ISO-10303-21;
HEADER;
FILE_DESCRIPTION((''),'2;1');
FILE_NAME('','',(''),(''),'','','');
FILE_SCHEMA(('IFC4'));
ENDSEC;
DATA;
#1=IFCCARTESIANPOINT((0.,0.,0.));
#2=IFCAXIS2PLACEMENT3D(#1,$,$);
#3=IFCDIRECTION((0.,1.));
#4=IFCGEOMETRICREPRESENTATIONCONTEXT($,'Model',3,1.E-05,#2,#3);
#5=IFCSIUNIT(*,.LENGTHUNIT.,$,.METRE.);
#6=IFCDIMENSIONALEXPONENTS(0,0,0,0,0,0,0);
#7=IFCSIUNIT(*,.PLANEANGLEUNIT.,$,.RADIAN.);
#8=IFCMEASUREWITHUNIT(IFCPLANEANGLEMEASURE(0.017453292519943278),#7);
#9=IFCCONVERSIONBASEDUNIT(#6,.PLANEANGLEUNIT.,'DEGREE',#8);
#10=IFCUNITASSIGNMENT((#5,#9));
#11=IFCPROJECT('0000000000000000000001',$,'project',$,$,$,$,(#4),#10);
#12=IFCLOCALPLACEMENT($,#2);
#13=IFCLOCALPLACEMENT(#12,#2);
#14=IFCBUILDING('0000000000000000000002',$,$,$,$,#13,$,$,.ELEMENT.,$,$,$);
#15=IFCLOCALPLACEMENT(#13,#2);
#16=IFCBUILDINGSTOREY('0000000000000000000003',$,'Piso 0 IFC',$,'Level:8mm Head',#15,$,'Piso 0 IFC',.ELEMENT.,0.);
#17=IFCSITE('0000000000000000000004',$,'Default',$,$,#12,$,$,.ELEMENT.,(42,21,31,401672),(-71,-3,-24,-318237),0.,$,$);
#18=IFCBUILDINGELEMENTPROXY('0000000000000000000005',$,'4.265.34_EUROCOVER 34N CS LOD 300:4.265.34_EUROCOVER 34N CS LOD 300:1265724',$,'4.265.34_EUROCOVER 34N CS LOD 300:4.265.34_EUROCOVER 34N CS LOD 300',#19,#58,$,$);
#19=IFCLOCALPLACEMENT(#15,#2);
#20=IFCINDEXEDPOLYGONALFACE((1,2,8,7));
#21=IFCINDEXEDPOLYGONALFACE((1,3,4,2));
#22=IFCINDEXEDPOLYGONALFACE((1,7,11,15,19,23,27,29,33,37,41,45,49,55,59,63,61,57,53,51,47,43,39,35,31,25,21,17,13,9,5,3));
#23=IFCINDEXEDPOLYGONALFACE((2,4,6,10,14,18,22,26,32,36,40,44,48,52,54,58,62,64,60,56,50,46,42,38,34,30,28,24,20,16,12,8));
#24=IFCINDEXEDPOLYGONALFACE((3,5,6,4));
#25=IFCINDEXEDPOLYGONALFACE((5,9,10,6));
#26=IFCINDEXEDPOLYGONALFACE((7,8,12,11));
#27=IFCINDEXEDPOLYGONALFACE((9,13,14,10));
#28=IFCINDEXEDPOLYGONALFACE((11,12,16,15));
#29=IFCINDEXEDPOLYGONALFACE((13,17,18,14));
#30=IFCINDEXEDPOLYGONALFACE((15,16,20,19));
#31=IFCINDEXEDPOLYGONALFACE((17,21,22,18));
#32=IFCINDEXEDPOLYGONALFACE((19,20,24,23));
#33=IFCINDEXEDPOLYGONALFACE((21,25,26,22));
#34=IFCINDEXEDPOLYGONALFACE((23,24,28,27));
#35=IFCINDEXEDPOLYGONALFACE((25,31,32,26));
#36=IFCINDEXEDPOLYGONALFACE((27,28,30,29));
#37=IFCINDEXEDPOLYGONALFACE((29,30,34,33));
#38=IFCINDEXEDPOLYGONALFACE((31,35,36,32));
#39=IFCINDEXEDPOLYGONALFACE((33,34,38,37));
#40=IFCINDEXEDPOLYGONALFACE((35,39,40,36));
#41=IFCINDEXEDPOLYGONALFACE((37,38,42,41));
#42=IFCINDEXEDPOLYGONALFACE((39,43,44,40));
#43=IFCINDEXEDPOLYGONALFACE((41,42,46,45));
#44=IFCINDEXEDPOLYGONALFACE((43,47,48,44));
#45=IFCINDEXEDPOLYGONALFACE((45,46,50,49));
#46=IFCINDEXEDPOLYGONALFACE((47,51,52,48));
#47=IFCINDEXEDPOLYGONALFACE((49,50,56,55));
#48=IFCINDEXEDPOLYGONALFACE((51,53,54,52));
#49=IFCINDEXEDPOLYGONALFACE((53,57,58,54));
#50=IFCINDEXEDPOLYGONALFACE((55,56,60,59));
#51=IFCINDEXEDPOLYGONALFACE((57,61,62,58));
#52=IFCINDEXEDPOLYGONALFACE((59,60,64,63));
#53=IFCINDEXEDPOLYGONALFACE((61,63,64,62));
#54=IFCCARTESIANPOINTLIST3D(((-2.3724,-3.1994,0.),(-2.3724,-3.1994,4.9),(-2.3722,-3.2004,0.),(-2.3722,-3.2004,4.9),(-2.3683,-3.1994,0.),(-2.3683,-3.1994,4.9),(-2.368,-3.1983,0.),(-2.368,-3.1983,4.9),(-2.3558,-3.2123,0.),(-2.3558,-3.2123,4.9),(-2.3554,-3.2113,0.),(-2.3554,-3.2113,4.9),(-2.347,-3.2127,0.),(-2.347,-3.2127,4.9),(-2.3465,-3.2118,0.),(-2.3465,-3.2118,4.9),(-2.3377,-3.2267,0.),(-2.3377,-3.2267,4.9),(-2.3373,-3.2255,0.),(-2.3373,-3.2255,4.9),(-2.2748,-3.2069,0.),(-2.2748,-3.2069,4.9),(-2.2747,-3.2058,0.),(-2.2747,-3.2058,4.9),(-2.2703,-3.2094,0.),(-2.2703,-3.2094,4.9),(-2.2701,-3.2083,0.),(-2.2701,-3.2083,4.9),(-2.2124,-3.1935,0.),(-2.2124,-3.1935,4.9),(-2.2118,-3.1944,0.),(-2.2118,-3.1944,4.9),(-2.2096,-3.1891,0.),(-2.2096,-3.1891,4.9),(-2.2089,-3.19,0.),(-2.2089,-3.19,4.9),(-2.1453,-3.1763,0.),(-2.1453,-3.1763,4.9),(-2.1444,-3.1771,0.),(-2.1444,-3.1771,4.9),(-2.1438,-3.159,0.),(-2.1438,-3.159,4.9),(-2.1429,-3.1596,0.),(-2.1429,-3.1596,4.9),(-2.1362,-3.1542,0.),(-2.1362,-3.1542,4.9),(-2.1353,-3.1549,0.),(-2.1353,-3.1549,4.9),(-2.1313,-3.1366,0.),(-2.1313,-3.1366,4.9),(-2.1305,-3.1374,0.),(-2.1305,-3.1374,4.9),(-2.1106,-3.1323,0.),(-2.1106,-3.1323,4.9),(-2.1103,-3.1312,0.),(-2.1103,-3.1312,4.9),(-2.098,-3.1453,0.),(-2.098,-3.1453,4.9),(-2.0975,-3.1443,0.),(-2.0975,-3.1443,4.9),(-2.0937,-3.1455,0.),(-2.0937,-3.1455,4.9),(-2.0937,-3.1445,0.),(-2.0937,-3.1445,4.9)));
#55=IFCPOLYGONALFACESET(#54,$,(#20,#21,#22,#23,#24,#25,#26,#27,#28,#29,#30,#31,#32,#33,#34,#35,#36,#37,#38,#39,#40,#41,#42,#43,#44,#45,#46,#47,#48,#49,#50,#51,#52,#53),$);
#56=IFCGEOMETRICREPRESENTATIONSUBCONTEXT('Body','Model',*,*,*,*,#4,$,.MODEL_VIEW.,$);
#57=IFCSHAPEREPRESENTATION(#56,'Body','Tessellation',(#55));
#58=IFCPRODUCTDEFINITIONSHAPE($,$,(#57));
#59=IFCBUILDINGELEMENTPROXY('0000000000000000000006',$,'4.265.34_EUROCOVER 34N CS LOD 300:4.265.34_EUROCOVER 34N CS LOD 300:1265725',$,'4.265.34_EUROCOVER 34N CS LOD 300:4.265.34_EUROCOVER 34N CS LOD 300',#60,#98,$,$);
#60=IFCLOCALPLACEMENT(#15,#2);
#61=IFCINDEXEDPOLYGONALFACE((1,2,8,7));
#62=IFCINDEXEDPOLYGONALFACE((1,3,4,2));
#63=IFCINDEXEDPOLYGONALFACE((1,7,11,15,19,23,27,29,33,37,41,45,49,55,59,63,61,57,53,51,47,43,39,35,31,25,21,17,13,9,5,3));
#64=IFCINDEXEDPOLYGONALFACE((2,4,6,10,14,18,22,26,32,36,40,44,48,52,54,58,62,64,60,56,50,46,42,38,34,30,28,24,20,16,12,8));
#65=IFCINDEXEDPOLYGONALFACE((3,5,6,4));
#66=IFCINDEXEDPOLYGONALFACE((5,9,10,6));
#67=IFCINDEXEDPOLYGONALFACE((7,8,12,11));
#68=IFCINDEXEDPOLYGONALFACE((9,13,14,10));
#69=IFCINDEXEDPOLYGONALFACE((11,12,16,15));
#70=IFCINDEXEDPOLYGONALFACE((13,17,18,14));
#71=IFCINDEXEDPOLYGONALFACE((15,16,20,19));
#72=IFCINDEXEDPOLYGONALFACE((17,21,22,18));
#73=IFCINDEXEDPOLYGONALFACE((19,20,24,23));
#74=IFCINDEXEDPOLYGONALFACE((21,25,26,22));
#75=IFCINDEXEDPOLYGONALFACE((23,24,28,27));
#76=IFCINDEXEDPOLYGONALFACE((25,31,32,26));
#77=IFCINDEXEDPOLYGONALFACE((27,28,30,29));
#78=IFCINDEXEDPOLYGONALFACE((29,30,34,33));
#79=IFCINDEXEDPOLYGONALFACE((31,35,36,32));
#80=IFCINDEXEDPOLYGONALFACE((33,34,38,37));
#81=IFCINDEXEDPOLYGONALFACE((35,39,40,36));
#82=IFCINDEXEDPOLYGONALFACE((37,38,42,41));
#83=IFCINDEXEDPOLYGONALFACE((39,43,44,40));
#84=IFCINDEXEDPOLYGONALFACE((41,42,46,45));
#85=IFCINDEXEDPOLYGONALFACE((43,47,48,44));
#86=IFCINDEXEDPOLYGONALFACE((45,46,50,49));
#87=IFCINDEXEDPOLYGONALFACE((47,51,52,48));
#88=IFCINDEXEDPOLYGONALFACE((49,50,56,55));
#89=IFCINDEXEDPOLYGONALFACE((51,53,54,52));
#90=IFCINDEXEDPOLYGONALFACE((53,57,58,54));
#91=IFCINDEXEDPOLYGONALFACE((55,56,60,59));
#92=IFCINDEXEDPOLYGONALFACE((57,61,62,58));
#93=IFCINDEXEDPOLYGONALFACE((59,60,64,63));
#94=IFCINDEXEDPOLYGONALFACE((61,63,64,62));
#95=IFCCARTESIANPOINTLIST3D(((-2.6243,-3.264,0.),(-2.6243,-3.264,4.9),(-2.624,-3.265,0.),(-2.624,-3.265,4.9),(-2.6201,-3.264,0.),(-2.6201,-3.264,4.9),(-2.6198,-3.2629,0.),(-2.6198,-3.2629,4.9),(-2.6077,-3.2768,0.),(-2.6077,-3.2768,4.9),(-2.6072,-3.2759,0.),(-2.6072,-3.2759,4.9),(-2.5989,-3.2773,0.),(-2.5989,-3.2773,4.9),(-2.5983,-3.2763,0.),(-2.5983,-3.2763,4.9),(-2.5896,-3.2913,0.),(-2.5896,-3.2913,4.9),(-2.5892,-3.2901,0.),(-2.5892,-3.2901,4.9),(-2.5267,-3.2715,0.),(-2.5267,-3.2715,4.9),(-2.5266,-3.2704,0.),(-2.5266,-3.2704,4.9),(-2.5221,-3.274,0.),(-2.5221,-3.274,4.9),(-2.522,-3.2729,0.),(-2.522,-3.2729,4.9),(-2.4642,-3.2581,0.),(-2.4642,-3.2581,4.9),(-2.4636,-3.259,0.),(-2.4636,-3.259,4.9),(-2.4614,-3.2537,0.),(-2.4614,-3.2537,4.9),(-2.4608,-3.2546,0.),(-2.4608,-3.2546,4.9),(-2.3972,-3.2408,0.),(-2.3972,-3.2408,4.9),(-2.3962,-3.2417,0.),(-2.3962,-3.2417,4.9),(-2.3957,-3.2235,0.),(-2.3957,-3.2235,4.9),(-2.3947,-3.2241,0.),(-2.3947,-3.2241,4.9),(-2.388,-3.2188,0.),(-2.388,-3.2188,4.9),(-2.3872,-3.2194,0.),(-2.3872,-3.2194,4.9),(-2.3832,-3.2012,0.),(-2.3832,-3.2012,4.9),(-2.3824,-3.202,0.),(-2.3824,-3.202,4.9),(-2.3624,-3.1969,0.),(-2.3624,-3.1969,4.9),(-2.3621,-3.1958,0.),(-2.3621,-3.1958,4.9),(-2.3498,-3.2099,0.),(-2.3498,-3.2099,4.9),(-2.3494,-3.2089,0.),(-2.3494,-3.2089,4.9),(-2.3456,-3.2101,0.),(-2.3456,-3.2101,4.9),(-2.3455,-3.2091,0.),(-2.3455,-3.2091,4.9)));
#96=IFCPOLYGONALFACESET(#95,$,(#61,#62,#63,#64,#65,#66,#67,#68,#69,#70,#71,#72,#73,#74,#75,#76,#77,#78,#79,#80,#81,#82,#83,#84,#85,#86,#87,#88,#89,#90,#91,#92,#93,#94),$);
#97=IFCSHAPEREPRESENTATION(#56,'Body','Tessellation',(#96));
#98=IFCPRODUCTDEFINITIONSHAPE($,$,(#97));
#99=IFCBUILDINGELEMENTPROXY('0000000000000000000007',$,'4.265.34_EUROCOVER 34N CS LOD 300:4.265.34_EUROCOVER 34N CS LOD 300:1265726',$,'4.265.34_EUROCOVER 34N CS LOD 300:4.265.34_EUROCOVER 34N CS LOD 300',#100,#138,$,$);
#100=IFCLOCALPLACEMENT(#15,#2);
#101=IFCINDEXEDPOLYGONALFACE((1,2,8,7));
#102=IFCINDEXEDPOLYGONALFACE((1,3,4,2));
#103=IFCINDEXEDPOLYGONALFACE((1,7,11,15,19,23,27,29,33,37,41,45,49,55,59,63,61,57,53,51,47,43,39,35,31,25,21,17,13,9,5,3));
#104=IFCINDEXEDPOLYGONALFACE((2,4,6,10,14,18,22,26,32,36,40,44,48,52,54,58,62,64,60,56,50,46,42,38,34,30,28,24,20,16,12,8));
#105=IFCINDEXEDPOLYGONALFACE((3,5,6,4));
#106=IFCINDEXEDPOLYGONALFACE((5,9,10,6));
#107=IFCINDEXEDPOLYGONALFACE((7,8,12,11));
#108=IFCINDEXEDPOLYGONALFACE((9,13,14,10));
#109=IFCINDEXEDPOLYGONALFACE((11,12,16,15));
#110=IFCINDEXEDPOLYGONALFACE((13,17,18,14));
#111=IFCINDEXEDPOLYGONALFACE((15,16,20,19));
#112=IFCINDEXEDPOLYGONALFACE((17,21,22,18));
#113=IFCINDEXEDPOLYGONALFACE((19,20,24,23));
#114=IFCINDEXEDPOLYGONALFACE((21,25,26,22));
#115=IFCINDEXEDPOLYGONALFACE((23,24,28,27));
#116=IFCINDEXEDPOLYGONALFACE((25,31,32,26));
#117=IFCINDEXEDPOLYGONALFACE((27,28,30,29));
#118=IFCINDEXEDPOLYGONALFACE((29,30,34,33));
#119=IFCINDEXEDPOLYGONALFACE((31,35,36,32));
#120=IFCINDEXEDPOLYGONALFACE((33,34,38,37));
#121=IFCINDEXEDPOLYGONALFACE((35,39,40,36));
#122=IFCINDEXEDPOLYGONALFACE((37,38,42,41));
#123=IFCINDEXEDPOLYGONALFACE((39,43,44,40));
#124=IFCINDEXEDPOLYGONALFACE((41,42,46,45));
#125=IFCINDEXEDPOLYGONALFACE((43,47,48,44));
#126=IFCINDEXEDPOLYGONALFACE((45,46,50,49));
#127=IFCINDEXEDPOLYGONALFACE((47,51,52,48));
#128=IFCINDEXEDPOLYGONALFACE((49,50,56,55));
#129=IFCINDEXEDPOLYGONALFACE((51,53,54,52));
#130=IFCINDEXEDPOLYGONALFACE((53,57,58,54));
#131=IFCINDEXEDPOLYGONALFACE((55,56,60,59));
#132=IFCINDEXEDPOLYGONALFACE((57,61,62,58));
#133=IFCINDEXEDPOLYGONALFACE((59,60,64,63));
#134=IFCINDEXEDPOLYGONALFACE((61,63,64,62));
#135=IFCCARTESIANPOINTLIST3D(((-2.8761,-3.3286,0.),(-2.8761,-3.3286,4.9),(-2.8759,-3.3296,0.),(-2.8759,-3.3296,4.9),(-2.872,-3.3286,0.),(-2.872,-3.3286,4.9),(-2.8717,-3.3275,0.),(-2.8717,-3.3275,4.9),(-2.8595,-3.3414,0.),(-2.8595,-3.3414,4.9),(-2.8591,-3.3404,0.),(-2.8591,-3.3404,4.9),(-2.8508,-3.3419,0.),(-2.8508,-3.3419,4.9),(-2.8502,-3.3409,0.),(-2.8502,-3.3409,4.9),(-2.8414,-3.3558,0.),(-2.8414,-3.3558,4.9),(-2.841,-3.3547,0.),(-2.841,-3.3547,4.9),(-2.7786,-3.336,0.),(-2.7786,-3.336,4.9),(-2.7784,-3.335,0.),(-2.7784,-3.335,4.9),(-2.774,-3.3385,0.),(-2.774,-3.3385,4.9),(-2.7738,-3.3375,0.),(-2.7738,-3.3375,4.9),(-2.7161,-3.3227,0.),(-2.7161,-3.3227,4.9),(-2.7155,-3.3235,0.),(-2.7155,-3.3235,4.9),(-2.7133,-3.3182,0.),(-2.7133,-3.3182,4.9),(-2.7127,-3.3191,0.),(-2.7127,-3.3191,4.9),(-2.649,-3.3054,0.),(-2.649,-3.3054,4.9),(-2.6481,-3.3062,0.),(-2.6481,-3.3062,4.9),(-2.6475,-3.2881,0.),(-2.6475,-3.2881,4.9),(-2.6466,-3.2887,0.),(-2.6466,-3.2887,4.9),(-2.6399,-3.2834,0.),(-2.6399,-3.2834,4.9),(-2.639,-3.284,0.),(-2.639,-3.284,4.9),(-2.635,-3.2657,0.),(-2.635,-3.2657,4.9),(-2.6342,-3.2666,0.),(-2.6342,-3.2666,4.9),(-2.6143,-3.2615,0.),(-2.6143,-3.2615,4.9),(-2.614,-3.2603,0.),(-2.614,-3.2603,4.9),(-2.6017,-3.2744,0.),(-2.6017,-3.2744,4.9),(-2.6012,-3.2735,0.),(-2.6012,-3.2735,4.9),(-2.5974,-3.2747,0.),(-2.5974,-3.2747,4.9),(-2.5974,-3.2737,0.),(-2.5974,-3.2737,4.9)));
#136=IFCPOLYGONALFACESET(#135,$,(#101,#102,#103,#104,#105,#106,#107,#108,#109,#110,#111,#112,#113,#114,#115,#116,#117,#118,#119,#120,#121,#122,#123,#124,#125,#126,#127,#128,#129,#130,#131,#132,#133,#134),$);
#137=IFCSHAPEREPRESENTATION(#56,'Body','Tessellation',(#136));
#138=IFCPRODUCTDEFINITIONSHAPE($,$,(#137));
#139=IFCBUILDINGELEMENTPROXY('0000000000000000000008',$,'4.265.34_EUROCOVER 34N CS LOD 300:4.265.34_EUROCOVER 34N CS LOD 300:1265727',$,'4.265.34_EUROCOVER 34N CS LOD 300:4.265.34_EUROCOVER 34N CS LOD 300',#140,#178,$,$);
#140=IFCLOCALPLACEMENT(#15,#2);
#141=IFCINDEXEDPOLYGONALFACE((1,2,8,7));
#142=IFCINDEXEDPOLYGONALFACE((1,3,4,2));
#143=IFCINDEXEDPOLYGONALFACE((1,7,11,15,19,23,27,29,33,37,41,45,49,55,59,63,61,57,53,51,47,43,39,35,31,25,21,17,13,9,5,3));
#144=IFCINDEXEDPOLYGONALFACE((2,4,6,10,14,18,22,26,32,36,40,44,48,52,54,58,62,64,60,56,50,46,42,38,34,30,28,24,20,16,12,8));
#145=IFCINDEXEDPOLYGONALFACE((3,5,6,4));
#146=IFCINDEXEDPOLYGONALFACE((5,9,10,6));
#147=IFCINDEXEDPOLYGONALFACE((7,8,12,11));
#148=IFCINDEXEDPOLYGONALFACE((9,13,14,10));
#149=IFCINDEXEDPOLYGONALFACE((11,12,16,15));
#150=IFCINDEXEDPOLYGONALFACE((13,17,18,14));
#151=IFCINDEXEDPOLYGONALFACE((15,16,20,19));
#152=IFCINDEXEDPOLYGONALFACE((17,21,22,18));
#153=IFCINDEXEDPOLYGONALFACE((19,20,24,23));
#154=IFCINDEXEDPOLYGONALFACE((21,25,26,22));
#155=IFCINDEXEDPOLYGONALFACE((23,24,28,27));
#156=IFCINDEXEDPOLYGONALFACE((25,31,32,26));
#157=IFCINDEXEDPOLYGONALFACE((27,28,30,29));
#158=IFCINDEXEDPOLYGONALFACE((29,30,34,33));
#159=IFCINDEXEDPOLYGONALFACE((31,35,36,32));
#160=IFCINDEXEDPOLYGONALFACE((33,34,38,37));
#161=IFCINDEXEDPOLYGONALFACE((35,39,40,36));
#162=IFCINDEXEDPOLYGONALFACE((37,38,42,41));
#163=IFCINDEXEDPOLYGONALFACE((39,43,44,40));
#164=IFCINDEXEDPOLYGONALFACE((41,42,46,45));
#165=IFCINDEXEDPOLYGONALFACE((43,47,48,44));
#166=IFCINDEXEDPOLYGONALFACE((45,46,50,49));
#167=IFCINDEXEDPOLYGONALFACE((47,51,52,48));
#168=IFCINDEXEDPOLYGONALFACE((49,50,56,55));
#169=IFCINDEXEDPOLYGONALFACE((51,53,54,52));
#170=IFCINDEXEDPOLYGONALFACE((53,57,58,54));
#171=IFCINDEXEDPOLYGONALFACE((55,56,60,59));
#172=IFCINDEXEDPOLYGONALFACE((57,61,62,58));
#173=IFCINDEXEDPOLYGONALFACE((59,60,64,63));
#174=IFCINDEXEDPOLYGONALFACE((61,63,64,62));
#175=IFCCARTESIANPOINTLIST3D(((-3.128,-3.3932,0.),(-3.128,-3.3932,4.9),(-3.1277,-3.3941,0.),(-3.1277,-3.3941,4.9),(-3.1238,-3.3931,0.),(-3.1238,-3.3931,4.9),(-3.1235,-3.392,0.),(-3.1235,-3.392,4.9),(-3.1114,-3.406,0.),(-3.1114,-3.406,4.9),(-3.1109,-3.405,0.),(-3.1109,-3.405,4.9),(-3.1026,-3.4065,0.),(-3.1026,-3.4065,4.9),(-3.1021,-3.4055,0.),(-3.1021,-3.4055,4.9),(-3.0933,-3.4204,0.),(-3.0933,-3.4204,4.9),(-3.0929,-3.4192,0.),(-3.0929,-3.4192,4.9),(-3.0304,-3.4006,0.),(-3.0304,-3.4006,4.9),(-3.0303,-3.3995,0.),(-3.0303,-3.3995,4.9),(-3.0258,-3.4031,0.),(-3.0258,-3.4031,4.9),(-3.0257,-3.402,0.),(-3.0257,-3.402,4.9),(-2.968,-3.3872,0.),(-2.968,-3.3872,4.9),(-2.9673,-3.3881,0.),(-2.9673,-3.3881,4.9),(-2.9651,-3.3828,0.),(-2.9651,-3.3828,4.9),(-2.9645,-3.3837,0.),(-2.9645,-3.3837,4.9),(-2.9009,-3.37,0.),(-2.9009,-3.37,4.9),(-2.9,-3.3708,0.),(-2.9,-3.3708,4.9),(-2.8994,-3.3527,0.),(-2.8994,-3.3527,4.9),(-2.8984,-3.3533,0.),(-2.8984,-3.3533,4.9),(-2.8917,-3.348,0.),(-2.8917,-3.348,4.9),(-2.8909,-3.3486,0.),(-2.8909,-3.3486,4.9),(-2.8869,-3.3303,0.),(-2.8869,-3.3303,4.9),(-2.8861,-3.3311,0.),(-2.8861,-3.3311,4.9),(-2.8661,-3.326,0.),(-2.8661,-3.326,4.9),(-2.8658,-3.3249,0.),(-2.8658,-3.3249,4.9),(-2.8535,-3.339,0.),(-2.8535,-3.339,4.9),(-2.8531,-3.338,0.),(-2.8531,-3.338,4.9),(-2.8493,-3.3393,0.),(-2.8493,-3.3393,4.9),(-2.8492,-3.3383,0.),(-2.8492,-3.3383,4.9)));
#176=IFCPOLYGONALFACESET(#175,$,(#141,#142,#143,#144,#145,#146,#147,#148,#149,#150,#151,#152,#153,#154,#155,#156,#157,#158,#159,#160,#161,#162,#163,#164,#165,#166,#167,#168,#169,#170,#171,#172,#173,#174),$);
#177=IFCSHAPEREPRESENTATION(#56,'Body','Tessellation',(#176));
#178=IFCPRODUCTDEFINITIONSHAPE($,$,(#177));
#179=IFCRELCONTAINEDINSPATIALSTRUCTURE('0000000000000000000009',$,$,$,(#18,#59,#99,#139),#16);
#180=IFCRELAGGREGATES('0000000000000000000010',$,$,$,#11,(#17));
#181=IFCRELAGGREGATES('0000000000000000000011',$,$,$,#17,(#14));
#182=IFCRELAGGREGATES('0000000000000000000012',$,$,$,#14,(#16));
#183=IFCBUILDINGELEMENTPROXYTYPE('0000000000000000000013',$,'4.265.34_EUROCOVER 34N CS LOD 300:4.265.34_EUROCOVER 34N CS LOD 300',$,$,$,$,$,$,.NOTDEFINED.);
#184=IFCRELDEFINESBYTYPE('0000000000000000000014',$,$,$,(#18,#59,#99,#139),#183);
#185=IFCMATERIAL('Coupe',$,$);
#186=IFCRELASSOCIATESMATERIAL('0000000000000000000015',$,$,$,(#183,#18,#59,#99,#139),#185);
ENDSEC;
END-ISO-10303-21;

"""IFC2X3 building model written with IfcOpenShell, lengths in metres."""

from ifc_helpers import new_model, entity, si_unit, converted_unit, direction, frame, origin, place, context, subcontext, project, spatial, polyline, outline, extrude, source, transform, mapped, material, type_object, type_shapes, element, save


model = new_model("IFC2X3")

# Units and contexts
model_context = context("Model", 3, precision=1e-05, world=origin(), true_north=direction((0.0, 1.0)))
body_context = subcontext(model_context, "Body", "Model", "MODEL_VIEW")
ifc_project = project(units=[si_unit("LENGTHUNIT", "METRE"), converted_unit("PLANEANGLEUNIT", "DEGREE", entity("IfcPlaneAngleMeasure", 0.017453292519943278), si_unit("PLANEANGLEUNIT", "RADIAN"), dimensions=[0, 0, 0, 0, 0, 0, 0])], contexts=[model_context])

# Site, building, storey
site_placement = place(None, origin())
site = spatial("IfcSite", under=ifc_project, at=site_placement, Name="Default", CompositionType="ELEMENT", RefLatitude=(42, 21, 31, 401672), RefLongitude=(-71, -3, -24, -318237), RefElevation=0.0)
building_placement = place(site_placement, origin())
building = spatial("IfcBuilding", under=site, at=building_placement, CompositionType="ELEMENT")
storey_placement = place(building_placement, origin())
storey = spatial("IfcBuildingStorey", under=building, at=storey_placement, Name="Piso 0 IFC", ObjectType="Level:8mm Head", LongName="Piso 0 IFC", CompositionType="ELEMENT", Elevation=0.0)

# Building element proxies
ifc_material_1 = material(Name="Coupe")
building_element_proxy_type = type_object("IfcBuildingElementProxyType", Name="4.265.34_EUROCOVER 34N CS LOD 300:4.265.34_EUROCOVER 34N CS LOD 300", PredefinedType="NOTDEFINED", material=ifc_material_1)
shared_shape_1 = source(origin(), body_context, "Body", "SweptSolid", [
    extrude(outline(polyline([(0.0449, 0.1162), (0.063, 0.1162), (0.0661, 0.1191), (0.0654, 0.1198), (0.0626, 0.1172), (0.0443, 0.1172), (0.0335, 0.0983), (0.0428, 0.0826), (0.0409, 0.0738), (0.0522, 0.0606), (0.0167, 0.0056), (0.0179, 0.0005), (-0.0117, -0.0512), (-0.0167, -0.0528), (-0.0462, -0.1114), (-0.0624, -0.1084), (-0.069, -0.1145), (-0.0871, -0.1145), (-0.0893, -0.1184), (-0.0885, -0.1189), (-0.0865, -0.1155), (-0.0686, -0.1155), (-0.0621, -0.1095), (-0.0456, -0.1125), (-0.016, -0.0536), (-0.0111, -0.0521), (0.0189, 0.0004), (0.0177, 0.0054), (0.0535, 0.0607), (0.0419, 0.074), (0.0438, 0.0827), (0.0347, 0.0983), (0.0449, 0.1162)])), frame((-0.0171, -0.0163, 0.0), z_axis=(0.0, 0.0, 1.0), x_axis=(-0.496574, 0.867994, 0.0)), (0.0, 0.0, 1.0), 4.9),
])
type_shapes(building_element_proxy_type, [shared_shape_1])
for number, where, z_axis, x_axis, name in (
    (1, (-2.2378, -3.2011, 0.0), (0.0, 0.0, 1.0), (-0.968666, -0.248367, 0.0), "4.265.34_EUROCOVER 34N CS LOD 300:4.265.34_EUROCOVER 34N CS LOD 300:1265724"),
    (2, (-2.4896, -3.2656, 0.0), (0.0, 0.0, 1.0), (-0.968666, -0.248367, 0.0), "4.265.34_EUROCOVER 34N CS LOD 300:4.265.34_EUROCOVER 34N CS LOD 300:1265725"),
    (3, (-2.7415, -3.3302, 0.0), (0.0, 0.0, 1.0), (-0.968666, -0.248367, 0.0), "4.265.34_EUROCOVER 34N CS LOD 300:4.265.34_EUROCOVER 34N CS LOD 300:1265726"),
    (4, (-2.9933, -3.3948, 0.0), (0.0, 0.0, 1.0), (-0.968666, -0.248367, 0.0), "4.265.34_EUROCOVER 34N CS LOD 300:4.265.34_EUROCOVER 34N CS LOD 300:1265727"),
):
    element("IfcBuildingElementProxy", number, at=place(storey_placement, frame(where, z_axis=z_axis, x_axis=x_axis)), inside=storey, type_object=building_element_proxy_type, material=ifc_material_1, Name=name, ObjectType="4.265.34_EUROCOVER 34N CS LOD 300:4.265.34_EUROCOVER 34N CS LOD 300", context=body_context, shape_type="MappedRepresentation", body=[
        mapped(shared_shape_1, transform((0.0, 0.0, 0.0), scale=1.0)),
    ])

save(model, "model.ifc")
